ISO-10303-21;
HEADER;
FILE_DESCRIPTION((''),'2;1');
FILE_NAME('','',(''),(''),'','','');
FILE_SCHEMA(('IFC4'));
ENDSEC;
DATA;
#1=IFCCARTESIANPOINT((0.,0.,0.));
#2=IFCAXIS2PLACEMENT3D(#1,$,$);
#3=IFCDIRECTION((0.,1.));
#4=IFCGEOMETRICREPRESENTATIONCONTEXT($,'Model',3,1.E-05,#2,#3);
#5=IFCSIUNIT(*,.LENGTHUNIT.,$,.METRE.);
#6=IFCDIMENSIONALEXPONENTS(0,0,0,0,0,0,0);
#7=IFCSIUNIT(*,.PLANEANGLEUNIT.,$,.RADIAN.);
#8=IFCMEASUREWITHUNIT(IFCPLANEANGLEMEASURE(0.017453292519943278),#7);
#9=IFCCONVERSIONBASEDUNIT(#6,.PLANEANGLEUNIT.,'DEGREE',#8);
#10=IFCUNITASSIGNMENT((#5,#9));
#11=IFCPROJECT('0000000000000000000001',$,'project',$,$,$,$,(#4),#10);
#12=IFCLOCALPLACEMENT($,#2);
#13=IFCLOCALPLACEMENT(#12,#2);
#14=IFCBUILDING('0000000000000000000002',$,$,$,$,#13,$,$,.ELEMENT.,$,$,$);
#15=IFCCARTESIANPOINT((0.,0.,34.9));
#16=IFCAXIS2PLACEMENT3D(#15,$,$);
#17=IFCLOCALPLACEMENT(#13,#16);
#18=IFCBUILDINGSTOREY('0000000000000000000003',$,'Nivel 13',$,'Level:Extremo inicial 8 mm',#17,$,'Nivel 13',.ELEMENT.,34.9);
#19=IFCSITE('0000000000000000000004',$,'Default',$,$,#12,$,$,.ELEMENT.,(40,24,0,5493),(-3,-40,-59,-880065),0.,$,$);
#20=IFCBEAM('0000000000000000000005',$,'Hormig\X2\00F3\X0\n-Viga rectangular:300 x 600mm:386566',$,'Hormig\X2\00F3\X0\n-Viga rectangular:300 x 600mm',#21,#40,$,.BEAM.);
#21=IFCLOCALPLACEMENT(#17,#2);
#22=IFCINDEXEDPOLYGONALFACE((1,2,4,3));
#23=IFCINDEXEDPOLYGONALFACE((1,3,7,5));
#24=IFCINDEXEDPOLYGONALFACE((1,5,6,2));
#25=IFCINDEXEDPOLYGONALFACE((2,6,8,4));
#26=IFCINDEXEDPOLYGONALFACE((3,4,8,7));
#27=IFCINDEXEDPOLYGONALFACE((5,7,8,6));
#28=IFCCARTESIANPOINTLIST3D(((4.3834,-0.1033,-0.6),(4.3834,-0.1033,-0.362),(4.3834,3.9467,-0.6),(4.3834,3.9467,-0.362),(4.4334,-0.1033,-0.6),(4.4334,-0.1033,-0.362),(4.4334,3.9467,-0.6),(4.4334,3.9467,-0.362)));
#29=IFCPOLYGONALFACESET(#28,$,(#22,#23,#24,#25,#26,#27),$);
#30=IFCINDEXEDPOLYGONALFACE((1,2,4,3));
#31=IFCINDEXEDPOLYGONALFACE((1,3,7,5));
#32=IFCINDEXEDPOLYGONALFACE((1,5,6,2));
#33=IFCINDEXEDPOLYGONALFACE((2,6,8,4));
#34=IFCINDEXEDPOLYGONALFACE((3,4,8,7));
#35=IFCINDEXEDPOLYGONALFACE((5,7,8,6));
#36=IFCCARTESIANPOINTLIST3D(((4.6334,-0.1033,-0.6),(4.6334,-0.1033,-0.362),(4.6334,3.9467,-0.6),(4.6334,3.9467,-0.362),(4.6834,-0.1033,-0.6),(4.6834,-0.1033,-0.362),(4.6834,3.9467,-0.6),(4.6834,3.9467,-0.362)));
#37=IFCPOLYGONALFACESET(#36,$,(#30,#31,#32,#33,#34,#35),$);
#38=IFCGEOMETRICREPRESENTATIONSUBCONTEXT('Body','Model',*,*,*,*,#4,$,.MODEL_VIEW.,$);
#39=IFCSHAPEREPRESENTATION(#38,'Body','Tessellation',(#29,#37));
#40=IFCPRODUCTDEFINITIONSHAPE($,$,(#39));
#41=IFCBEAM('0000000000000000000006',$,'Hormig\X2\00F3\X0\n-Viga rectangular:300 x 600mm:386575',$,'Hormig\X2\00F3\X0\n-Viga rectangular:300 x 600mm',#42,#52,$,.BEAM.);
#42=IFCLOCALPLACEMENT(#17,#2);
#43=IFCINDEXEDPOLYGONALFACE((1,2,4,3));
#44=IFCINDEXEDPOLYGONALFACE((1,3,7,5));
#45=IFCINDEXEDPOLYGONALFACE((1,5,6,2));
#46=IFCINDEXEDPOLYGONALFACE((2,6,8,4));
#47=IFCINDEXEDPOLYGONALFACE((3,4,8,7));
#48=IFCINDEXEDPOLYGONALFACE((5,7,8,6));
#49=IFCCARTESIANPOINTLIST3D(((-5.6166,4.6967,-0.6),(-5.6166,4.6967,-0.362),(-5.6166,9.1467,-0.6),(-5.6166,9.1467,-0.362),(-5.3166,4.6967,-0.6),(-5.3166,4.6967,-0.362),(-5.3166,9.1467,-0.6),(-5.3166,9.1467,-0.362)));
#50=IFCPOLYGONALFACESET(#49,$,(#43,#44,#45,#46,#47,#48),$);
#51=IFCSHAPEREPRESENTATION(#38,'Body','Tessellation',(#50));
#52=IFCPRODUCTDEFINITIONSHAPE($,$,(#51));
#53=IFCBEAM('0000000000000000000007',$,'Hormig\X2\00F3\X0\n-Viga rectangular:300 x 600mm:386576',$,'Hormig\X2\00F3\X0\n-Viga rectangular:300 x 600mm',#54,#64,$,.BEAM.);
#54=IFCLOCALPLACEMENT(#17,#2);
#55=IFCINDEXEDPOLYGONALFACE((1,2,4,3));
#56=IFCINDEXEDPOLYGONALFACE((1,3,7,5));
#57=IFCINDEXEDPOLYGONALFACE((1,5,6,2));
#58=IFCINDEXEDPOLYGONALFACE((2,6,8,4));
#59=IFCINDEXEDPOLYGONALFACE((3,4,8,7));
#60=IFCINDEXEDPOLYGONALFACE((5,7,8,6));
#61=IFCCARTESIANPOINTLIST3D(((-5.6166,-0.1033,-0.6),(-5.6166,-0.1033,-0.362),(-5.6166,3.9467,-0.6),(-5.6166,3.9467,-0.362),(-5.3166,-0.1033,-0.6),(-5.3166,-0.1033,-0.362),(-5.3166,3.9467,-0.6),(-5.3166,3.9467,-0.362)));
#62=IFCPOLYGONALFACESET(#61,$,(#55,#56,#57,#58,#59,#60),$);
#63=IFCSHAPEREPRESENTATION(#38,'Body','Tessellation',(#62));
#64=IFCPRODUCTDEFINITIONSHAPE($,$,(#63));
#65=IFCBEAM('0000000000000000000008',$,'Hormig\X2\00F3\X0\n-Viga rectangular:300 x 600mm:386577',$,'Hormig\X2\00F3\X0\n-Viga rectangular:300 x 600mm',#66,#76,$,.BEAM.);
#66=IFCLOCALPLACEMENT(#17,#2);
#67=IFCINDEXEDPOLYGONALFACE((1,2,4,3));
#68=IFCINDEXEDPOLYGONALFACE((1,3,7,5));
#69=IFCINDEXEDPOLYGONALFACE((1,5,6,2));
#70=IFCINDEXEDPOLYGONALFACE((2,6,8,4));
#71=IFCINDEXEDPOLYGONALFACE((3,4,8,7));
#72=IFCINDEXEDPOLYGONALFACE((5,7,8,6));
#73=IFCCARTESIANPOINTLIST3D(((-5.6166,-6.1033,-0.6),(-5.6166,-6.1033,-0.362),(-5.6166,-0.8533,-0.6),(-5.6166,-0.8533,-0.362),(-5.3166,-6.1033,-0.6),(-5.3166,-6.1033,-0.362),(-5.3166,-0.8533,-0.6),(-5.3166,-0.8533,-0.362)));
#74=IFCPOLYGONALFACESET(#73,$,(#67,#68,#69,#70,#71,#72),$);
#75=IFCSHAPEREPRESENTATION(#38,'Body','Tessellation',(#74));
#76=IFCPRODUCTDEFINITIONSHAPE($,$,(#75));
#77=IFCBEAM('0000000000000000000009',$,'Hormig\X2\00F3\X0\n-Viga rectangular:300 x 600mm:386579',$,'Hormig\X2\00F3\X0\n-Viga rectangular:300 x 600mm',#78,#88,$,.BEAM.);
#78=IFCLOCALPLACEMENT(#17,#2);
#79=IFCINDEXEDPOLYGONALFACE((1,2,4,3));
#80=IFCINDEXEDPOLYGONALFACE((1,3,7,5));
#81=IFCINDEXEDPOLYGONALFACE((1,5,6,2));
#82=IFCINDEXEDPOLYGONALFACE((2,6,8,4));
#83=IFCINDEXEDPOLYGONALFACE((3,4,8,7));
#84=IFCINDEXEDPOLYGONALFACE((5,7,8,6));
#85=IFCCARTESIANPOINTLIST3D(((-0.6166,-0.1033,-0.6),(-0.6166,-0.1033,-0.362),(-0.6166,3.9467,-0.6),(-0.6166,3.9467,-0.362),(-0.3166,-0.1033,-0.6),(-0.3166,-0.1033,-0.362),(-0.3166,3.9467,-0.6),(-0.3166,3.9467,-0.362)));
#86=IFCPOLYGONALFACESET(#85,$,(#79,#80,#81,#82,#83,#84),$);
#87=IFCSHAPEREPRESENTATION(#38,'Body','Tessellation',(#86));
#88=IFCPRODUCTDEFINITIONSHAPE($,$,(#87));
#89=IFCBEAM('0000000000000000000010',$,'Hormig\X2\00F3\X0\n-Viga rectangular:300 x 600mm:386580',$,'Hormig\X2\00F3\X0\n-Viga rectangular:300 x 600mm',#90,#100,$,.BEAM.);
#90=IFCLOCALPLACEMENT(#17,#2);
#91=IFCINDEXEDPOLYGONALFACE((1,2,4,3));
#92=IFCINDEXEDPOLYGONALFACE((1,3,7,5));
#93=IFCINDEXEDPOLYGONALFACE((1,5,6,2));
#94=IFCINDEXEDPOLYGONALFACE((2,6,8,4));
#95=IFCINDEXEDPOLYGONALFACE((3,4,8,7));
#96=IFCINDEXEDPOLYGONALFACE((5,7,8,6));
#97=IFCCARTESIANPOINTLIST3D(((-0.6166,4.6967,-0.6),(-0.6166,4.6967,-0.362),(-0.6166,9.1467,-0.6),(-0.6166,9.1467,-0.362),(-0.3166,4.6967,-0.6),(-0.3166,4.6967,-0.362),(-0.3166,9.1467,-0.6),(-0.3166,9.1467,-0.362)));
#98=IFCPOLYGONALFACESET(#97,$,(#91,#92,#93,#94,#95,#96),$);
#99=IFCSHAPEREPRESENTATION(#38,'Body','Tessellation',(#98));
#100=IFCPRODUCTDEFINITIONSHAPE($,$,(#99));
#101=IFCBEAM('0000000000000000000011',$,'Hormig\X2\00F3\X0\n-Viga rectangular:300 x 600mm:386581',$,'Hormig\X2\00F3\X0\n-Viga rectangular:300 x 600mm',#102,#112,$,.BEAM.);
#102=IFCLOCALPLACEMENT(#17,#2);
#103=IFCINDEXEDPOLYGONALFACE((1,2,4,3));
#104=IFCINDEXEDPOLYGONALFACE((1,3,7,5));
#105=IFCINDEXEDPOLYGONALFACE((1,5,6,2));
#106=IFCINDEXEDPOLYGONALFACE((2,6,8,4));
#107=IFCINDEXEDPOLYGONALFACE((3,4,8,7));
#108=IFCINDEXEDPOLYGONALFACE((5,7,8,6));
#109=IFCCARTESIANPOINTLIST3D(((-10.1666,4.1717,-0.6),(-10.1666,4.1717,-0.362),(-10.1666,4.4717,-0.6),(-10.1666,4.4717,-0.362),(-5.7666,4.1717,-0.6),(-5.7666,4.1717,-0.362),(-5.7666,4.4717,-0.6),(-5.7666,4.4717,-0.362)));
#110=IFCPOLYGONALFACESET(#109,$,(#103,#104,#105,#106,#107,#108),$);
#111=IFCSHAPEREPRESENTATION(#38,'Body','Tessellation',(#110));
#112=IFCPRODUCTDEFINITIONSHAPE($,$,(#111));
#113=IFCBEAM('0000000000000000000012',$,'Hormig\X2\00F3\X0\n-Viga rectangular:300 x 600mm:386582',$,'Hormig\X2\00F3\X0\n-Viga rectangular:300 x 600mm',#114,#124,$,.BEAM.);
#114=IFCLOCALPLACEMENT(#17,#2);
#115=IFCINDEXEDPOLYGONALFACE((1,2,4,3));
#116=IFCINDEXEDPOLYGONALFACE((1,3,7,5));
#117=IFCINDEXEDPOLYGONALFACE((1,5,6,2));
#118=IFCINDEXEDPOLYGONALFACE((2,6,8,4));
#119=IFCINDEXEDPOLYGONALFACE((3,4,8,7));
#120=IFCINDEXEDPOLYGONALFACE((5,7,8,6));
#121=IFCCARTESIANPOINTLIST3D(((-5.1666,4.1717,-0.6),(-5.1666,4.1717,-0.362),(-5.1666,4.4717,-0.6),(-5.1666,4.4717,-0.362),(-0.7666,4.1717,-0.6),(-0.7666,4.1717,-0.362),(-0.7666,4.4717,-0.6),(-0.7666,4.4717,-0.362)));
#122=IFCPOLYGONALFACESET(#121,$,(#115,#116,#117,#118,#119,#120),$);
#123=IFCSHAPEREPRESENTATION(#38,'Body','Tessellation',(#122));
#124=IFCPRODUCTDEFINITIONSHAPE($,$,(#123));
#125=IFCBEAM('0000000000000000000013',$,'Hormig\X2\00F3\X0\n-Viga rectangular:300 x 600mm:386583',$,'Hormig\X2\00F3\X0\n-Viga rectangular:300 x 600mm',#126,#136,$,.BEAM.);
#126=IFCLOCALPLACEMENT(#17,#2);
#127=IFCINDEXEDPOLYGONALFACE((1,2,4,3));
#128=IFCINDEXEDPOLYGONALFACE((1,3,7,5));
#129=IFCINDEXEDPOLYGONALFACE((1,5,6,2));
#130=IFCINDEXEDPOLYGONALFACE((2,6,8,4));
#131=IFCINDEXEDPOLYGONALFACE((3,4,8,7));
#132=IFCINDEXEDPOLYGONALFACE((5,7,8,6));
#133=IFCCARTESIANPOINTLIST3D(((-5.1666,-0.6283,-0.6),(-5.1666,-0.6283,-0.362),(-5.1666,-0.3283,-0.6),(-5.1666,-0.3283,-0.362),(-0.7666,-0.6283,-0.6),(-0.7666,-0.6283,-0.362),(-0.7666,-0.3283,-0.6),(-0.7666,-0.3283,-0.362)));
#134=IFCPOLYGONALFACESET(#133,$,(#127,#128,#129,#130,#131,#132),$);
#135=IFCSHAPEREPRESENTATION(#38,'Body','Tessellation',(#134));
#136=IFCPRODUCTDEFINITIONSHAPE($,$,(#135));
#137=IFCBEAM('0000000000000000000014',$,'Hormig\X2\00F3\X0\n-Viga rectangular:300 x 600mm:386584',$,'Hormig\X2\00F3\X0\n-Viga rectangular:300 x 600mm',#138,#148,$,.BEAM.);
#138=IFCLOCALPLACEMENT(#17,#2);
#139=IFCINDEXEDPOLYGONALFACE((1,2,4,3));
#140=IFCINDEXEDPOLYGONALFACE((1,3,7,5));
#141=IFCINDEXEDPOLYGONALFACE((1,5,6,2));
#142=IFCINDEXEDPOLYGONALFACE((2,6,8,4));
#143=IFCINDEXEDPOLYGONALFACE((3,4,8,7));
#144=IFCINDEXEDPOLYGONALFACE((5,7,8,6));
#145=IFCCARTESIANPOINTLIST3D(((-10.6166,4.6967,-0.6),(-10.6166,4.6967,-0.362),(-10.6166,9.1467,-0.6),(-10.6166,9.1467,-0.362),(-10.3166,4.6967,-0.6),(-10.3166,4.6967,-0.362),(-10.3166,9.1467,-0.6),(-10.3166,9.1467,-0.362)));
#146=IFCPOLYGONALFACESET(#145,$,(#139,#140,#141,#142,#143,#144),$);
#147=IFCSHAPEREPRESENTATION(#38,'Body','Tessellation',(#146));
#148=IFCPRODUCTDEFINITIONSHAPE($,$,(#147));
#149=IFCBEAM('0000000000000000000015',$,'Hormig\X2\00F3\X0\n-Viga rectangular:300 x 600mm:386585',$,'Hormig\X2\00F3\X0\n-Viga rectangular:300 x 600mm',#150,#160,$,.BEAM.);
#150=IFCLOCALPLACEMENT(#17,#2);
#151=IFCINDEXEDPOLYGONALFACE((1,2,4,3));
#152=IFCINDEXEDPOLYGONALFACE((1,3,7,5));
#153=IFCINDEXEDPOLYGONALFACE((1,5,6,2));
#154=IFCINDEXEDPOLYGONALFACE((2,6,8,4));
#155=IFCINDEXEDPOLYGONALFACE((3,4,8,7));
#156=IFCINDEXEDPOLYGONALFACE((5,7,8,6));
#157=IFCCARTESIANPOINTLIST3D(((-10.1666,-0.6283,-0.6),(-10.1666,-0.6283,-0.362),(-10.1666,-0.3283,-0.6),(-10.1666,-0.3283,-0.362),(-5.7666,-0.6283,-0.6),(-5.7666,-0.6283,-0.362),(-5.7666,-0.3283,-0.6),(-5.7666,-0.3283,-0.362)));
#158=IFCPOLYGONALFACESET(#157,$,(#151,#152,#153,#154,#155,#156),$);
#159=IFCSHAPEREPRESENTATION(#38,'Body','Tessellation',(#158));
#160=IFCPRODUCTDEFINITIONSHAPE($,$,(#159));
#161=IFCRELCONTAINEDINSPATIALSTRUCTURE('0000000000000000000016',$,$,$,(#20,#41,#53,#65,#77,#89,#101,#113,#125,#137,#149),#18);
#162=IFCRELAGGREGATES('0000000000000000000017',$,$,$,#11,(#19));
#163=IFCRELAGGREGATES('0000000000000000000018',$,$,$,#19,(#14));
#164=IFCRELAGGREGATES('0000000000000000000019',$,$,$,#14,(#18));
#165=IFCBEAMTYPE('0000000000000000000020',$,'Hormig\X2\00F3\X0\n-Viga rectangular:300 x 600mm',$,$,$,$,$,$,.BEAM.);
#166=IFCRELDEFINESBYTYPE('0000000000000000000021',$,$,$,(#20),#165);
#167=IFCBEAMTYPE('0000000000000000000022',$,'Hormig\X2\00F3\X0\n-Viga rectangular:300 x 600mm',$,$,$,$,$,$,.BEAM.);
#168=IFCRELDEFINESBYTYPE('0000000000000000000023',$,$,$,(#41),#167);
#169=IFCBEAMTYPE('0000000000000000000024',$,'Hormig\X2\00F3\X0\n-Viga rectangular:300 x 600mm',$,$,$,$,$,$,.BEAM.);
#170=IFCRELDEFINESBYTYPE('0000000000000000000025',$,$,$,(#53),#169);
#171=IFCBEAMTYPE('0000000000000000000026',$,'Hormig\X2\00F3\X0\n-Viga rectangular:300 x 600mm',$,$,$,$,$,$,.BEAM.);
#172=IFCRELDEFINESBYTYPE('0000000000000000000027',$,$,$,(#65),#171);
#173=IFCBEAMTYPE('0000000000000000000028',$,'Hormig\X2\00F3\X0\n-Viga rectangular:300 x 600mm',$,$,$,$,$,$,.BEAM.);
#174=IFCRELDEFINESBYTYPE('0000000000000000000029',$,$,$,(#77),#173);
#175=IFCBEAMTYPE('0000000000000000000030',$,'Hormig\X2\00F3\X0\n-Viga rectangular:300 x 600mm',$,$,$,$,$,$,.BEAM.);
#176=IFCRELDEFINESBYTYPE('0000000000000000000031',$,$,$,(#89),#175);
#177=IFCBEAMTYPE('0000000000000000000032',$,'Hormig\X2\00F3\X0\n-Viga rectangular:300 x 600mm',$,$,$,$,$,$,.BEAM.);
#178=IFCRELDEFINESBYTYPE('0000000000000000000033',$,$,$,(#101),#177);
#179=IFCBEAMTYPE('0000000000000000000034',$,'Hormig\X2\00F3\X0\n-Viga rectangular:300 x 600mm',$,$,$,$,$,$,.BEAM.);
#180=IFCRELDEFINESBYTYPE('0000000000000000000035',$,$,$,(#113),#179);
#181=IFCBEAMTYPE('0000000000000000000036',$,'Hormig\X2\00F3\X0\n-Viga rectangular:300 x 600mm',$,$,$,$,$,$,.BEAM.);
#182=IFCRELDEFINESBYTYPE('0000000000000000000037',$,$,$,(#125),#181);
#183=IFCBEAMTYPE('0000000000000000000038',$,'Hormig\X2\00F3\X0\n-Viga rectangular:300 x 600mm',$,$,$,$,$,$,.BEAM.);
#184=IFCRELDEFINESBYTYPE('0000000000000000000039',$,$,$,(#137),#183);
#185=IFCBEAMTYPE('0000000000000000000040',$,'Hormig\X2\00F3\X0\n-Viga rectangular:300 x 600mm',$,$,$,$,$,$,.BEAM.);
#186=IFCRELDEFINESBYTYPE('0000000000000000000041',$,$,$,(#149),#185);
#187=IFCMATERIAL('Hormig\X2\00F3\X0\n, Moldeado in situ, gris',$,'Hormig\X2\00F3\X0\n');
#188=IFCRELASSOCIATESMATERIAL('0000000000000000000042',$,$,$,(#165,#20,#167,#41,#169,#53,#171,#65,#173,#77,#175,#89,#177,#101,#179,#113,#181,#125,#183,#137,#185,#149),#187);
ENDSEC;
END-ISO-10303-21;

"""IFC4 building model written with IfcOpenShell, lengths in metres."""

from ifc_helpers import new_model, entity, si_unit, converted_unit, direction, frame, origin, place, context, subcontext, project, spatial, indexed_curve, outline, extrude, source, transform, mapped, material, type_object, type_shapes, element, save


model = new_model("IFC4")

# Units and contexts
model_context = context("Model", 3, precision=1e-05, world=origin(), true_north=direction((0.0, 1.0)))
body_context = subcontext(model_context, "Body", "Model", "MODEL_VIEW")
ifc_project = project(units=[si_unit("LENGTHUNIT", "METRE"), converted_unit("PLANEANGLEUNIT", "DEGREE", entity("IfcPlaneAngleMeasure", 0.017453292519943278), si_unit("PLANEANGLEUNIT", "RADIAN"), dimensions=[0, 0, 0, 0, 0, 0, 0])], contexts=[model_context])

# Site, building, storey
site_placement = place(None, origin())
site = spatial("IfcSite", under=ifc_project, at=site_placement, Name="Default", CompositionType="ELEMENT", RefLatitude=(40, 24, 0, 5493), RefLongitude=(-3, -40, -59, -880065), RefElevation=0.0)
building_placement = place(site_placement, origin())
building = spatial("IfcBuilding", under=site, at=building_placement, CompositionType="ELEMENT")
storey_placement = place(building_placement, frame((0.0, 0.0, 34.9)))
storey = spatial("IfcBuildingStorey", under=building, at=storey_placement, Name="Nivel 13", ObjectType="Level:Extremo inicial 8 mm", LongName="Nivel 13", CompositionType="ELEMENT", Elevation=34.9)

# Shared definitions
ifc_material_1 = material(Name="Hormigón, Moldeado in situ, gris", Category="Hormigón")

# Beams
beam_type_1 = type_object("IfcBeamType", Name="Hormigón-Viga rectangular:300 x 600mm", PredefinedType="BEAM", material=ifc_material_1)
shared_shape_1 = source(origin(), body_context, "Body", "SweptSolid", [
    extrude(outline(indexed_curve([(-0.025, -0.119), (0.025, -0.119), (0.025, 0.119), (-0.025, 0.119), (-0.025, -0.119)], self_intersect=False)), frame((4.4084, 3.9467, 34.419), z_axis=(0.0, -1.0, 0.0), x_axis=(-1.0, 0.0, 0.0)), (0.0, 0.0, 1.0), 4.05),
    extrude(outline(indexed_curve([(-0.025, -0.119), (0.025, -0.119), (0.025, 0.119), (-0.025, 0.119), (-0.025, -0.119)], self_intersect=False)), frame((4.6584, 3.9467, 34.419), z_axis=(0.0, -1.0, 0.0), x_axis=(-1.0, 0.0, 0.0)), (0.0, 0.0, 1.0), 4.05),
])
type_shapes(beam_type_1, [shared_shape_1])
beam_1_placement = place(storey_placement, frame((0.0, 0.0, -34.9)))
element("IfcBeam", 1, at=beam_1_placement, inside=storey, type_object=beam_type_1, material=ifc_material_1, Name="Hormigón-Viga rectangular:300 x 600mm:386566", ObjectType="Hormigón-Viga rectangular:300 x 600mm", PredefinedType="BEAM", context=body_context, shape_type="MappedRepresentation", body=[
    mapped(shared_shape_1, transform((0.0, 0.0, 0.0), scale=1.0)),
])
beam_type_2 = type_object("IfcBeamType", Name="Hormigón-Viga rectangular:300 x 600mm", PredefinedType="BEAM", material=ifc_material_1)
shared_shape_2 = source(origin(), body_context, "Body", "SweptSolid", [
    extrude(outline(indexed_curve([(-0.15, -0.119), (0.15, -0.119), (0.15, 0.119), (-0.15, 0.119), (-0.15, -0.119)], self_intersect=False)), frame((-5.4666, 9.1467, 34.419), z_axis=(0.0, -1.0, 0.0), x_axis=(-1.0, 0.0, 0.0)), (0.0, 0.0, 1.0), 4.45),
])
type_shapes(beam_type_2, [shared_shape_2])
beam_2_placement = place(storey_placement, frame((0.0, 0.0, -34.9)))
element("IfcBeam", 2, at=beam_2_placement, inside=storey, type_object=beam_type_2, material=ifc_material_1, Name="Hormigón-Viga rectangular:300 x 600mm:386575", ObjectType="Hormigón-Viga rectangular:300 x 600mm", PredefinedType="BEAM", context=body_context, shape_type="MappedRepresentation", body=[
    mapped(shared_shape_2, transform((0.0, 0.0, 0.0), scale=1.0)),
])
beam_type_3 = type_object("IfcBeamType", Name="Hormigón-Viga rectangular:300 x 600mm", PredefinedType="BEAM", material=ifc_material_1)
shared_shape_3 = source(origin(), body_context, "Body", "SweptSolid", [
    extrude(outline(indexed_curve([(-0.15, -0.119), (0.15, -0.119), (0.15, 0.119), (-0.15, 0.119), (-0.15, -0.119)], self_intersect=False)), frame((-5.4666, 3.9467, 34.419), z_axis=(0.0, -1.0, 0.0), x_axis=(-1.0, 0.0, 0.0)), (0.0, 0.0, 1.0), 4.05),
])
type_shapes(beam_type_3, [shared_shape_3])
beam_3_placement = place(storey_placement, frame((0.0, 0.0, -34.9)))
element("IfcBeam", 3, at=beam_3_placement, inside=storey, type_object=beam_type_3, material=ifc_material_1, Name="Hormigón-Viga rectangular:300 x 600mm:386576", ObjectType="Hormigón-Viga rectangular:300 x 600mm", PredefinedType="BEAM", context=body_context, shape_type="MappedRepresentation", body=[
    mapped(shared_shape_3, transform((0.0, 0.0, 0.0), scale=1.0)),
])
beam_type_4 = type_object("IfcBeamType", Name="Hormigón-Viga rectangular:300 x 600mm", PredefinedType="BEAM", material=ifc_material_1)
shared_shape_4 = source(origin(), body_context, "Body", "SweptSolid", [
    extrude(outline(indexed_curve([(-0.15, -0.119), (0.15, -0.119), (0.15, 0.119), (-0.15, 0.119), (-0.15, -0.119)], self_intersect=False)), frame((-5.4666, -6.1033, 34.419), z_axis=(0.0, 1.0, 0.0), x_axis=(-1.0, 0.0, 0.0)), (0.0, 0.0, 1.0), 5.25),
])
type_shapes(beam_type_4, [shared_shape_4])
beam_4_placement = place(storey_placement, frame((0.0, 0.0, -34.9)))
element("IfcBeam", 4, at=beam_4_placement, inside=storey, type_object=beam_type_4, material=ifc_material_1, Name="Hormigón-Viga rectangular:300 x 600mm:386577", ObjectType="Hormigón-Viga rectangular:300 x 600mm", PredefinedType="BEAM", context=body_context, shape_type="MappedRepresentation", body=[
    mapped(shared_shape_4, transform((0.0, 0.0, 0.0), scale=1.0)),
])
beam_type_5 = type_object("IfcBeamType", Name="Hormigón-Viga rectangular:300 x 600mm", PredefinedType="BEAM", material=ifc_material_1)
shared_shape_5 = source(origin(), body_context, "Body", "SweptSolid", [
    extrude(outline(indexed_curve([(-0.15, -0.119), (0.15, -0.119), (0.15, 0.119), (-0.15, 0.119), (-0.15, -0.119)], self_intersect=False)), frame((-0.4666, -0.1033, 34.419), z_axis=(0.0, 1.0, 0.0), x_axis=(-1.0, 0.0, 0.0)), (0.0, 0.0, 1.0), 4.05),
])
type_shapes(beam_type_5, [shared_shape_5])
beam_5_placement = place(storey_placement, frame((0.0, 0.0, -34.9)))
element("IfcBeam", 5, at=beam_5_placement, inside=storey, type_object=beam_type_5, material=ifc_material_1, Name="Hormigón-Viga rectangular:300 x 600mm:386579", ObjectType="Hormigón-Viga rectangular:300 x 600mm", PredefinedType="BEAM", context=body_context, shape_type="MappedRepresentation", body=[
    mapped(shared_shape_5, transform((0.0, 0.0, 0.0), scale=1.0)),
])
beam_type_6 = type_object("IfcBeamType", Name="Hormigón-Viga rectangular:300 x 600mm", PredefinedType="BEAM", material=ifc_material_1)
shared_shape_6 = source(origin(), body_context, "Body", "SweptSolid", [
    extrude(outline(indexed_curve([(-0.15, -0.119), (0.15, -0.119), (0.15, 0.119), (-0.15, 0.119), (-0.15, -0.119)], self_intersect=False)), frame((-0.4666, 9.1467, 34.419), z_axis=(0.0, -1.0, 0.0), x_axis=(-1.0, 0.0, 0.0)), (0.0, 0.0, 1.0), 4.45),
])
type_shapes(beam_type_6, [shared_shape_6])
beam_6_placement = place(storey_placement, frame((0.0, 0.0, -34.9)))
element("IfcBeam", 6, at=beam_6_placement, inside=storey, type_object=beam_type_6, material=ifc_material_1, Name="Hormigón-Viga rectangular:300 x 600mm:386580", ObjectType="Hormigón-Viga rectangular:300 x 600mm", PredefinedType="BEAM", context=body_context, shape_type="MappedRepresentation", body=[
    mapped(shared_shape_6, transform((0.0, 0.0, 0.0), scale=1.0)),
])
beam_type_7 = type_object("IfcBeamType", Name="Hormigón-Viga rectangular:300 x 600mm", PredefinedType="BEAM", material=ifc_material_1)
shared_shape_7 = source(origin(), body_context, "Body", "SweptSolid", [
    extrude(outline(indexed_curve([(-0.119, -0.15), (0.119, -0.15), (0.119, 0.15), (-0.119, 0.15), (-0.119, -0.15)], self_intersect=False)), frame((-10.1666, 4.3217, 34.419), z_axis=(1.0, 0.0, 0.0), x_axis=(0.0, 0.0, -1.0)), (0.0, 0.0, 1.0), 4.4),
])
type_shapes(beam_type_7, [shared_shape_7])
beam_7_placement = place(storey_placement, frame((0.0, 0.0, -34.9)))
element("IfcBeam", 7, at=beam_7_placement, inside=storey, type_object=beam_type_7, material=ifc_material_1, Name="Hormigón-Viga rectangular:300 x 600mm:386581", ObjectType="Hormigón-Viga rectangular:300 x 600mm", PredefinedType="BEAM", context=body_context, shape_type="MappedRepresentation", body=[
    mapped(shared_shape_7, transform((0.0, 0.0, 0.0), scale=1.0)),
])
beam_type_8 = type_object("IfcBeamType", Name="Hormigón-Viga rectangular:300 x 600mm", PredefinedType="BEAM", material=ifc_material_1)
shared_shape_8 = source(origin(), body_context, "Body", "SweptSolid", [
    extrude(outline(indexed_curve([(-0.119, -0.15), (0.119, -0.15), (0.119, 0.15), (-0.119, 0.15), (-0.119, -0.15)], self_intersect=False)), frame((-5.1666, 4.3217, 34.419), z_axis=(1.0, 0.0, 0.0), x_axis=(0.0, 0.0, -1.0)), (0.0, 0.0, 1.0), 4.4),
])
type_shapes(beam_type_8, [shared_shape_8])
beam_8_placement = place(storey_placement, frame((0.0, 0.0, -34.9)))
element("IfcBeam", 8, at=beam_8_placement, inside=storey, type_object=beam_type_8, material=ifc_material_1, Name="Hormigón-Viga rectangular:300 x 600mm:386582", ObjectType="Hormigón-Viga rectangular:300 x 600mm", PredefinedType="BEAM", context=body_context, shape_type="MappedRepresentation", body=[
    mapped(shared_shape_8, transform((0.0, 0.0, 0.0), scale=1.0)),
])
beam_type_9 = type_object("IfcBeamType", Name="Hormigón-Viga rectangular:300 x 600mm", PredefinedType="BEAM", material=ifc_material_1)
shared_shape_9 = source(origin(), body_context, "Body", "SweptSolid", [
    extrude(outline(indexed_curve([(-0.119, -0.15), (0.119, -0.15), (0.119, 0.15), (-0.119, 0.15), (-0.119, -0.15)], self_intersect=False)), frame((-0.7666, -0.4783, 34.419), z_axis=(-1.0, 0.0, 0.0), x_axis=(0.0, 0.0, -1.0)), (0.0, 0.0, 1.0), 4.4),
])
type_shapes(beam_type_9, [shared_shape_9])
beam_9_placement = place(storey_placement, frame((0.0, 0.0, -34.9)))
element("IfcBeam", 9, at=beam_9_placement, inside=storey, type_object=beam_type_9, material=ifc_material_1, Name="Hormigón-Viga rectangular:300 x 600mm:386583", ObjectType="Hormigón-Viga rectangular:300 x 600mm", PredefinedType="BEAM", context=body_context, shape_type="MappedRepresentation", body=[
    mapped(shared_shape_9, transform((0.0, 0.0, 0.0), scale=1.0)),
])
beam_type_10 = type_object("IfcBeamType", Name="Hormigón-Viga rectangular:300 x 600mm", PredefinedType="BEAM", material=ifc_material_1)
shared_shape_10 = source(origin(), body_context, "Body", "SweptSolid", [
    extrude(outline(indexed_curve([(-0.15, -0.119), (0.15, -0.119), (0.15, 0.119), (-0.15, 0.119), (-0.15, -0.119)], self_intersect=False)), frame((-10.4666, 4.6967, 34.419), z_axis=(0.0, 1.0, 0.0), x_axis=(-1.0, 0.0, 0.0)), (0.0, 0.0, 1.0), 4.45),
])
type_shapes(beam_type_10, [shared_shape_10])
beam_10_placement = place(storey_placement, frame((0.0, 0.0, -34.9)))
element("IfcBeam", 10, at=beam_10_placement, inside=storey, type_object=beam_type_10, material=ifc_material_1, Name="Hormigón-Viga rectangular:300 x 600mm:386584", ObjectType="Hormigón-Viga rectangular:300 x 600mm", PredefinedType="BEAM", context=body_context, shape_type="MappedRepresentation", body=[
    mapped(shared_shape_10, transform((0.0, 0.0, 0.0), scale=1.0)),
])
beam_type_11 = type_object("IfcBeamType", Name="Hormigón-Viga rectangular:300 x 600mm", PredefinedType="BEAM", material=ifc_material_1)
shared_shape_11 = source(origin(), body_context, "Body", "SweptSolid", [
    extrude(outline(indexed_curve([(-0.119, -0.15), (0.119, -0.15), (0.119, 0.15), (-0.119, 0.15), (-0.119, -0.15)], self_intersect=False)), frame((-10.1666, -0.4783, 34.419), z_axis=(1.0, 0.0, 0.0), x_axis=(0.0, 0.0, -1.0)), (0.0, 0.0, 1.0), 4.4),
])
type_shapes(beam_type_11, [shared_shape_11])
beam_11_placement = place(storey_placement, frame((0.0, 0.0, -34.9)))
element("IfcBeam", 11, at=beam_11_placement, inside=storey, type_object=beam_type_11, material=ifc_material_1, Name="Hormigón-Viga rectangular:300 x 600mm:386585", ObjectType="Hormigón-Viga rectangular:300 x 600mm", PredefinedType="BEAM", context=body_context, shape_type="MappedRepresentation", body=[
    mapped(shared_shape_11, transform((0.0, 0.0, 0.0), scale=1.0)),
])

save(model, "model.ifc")
